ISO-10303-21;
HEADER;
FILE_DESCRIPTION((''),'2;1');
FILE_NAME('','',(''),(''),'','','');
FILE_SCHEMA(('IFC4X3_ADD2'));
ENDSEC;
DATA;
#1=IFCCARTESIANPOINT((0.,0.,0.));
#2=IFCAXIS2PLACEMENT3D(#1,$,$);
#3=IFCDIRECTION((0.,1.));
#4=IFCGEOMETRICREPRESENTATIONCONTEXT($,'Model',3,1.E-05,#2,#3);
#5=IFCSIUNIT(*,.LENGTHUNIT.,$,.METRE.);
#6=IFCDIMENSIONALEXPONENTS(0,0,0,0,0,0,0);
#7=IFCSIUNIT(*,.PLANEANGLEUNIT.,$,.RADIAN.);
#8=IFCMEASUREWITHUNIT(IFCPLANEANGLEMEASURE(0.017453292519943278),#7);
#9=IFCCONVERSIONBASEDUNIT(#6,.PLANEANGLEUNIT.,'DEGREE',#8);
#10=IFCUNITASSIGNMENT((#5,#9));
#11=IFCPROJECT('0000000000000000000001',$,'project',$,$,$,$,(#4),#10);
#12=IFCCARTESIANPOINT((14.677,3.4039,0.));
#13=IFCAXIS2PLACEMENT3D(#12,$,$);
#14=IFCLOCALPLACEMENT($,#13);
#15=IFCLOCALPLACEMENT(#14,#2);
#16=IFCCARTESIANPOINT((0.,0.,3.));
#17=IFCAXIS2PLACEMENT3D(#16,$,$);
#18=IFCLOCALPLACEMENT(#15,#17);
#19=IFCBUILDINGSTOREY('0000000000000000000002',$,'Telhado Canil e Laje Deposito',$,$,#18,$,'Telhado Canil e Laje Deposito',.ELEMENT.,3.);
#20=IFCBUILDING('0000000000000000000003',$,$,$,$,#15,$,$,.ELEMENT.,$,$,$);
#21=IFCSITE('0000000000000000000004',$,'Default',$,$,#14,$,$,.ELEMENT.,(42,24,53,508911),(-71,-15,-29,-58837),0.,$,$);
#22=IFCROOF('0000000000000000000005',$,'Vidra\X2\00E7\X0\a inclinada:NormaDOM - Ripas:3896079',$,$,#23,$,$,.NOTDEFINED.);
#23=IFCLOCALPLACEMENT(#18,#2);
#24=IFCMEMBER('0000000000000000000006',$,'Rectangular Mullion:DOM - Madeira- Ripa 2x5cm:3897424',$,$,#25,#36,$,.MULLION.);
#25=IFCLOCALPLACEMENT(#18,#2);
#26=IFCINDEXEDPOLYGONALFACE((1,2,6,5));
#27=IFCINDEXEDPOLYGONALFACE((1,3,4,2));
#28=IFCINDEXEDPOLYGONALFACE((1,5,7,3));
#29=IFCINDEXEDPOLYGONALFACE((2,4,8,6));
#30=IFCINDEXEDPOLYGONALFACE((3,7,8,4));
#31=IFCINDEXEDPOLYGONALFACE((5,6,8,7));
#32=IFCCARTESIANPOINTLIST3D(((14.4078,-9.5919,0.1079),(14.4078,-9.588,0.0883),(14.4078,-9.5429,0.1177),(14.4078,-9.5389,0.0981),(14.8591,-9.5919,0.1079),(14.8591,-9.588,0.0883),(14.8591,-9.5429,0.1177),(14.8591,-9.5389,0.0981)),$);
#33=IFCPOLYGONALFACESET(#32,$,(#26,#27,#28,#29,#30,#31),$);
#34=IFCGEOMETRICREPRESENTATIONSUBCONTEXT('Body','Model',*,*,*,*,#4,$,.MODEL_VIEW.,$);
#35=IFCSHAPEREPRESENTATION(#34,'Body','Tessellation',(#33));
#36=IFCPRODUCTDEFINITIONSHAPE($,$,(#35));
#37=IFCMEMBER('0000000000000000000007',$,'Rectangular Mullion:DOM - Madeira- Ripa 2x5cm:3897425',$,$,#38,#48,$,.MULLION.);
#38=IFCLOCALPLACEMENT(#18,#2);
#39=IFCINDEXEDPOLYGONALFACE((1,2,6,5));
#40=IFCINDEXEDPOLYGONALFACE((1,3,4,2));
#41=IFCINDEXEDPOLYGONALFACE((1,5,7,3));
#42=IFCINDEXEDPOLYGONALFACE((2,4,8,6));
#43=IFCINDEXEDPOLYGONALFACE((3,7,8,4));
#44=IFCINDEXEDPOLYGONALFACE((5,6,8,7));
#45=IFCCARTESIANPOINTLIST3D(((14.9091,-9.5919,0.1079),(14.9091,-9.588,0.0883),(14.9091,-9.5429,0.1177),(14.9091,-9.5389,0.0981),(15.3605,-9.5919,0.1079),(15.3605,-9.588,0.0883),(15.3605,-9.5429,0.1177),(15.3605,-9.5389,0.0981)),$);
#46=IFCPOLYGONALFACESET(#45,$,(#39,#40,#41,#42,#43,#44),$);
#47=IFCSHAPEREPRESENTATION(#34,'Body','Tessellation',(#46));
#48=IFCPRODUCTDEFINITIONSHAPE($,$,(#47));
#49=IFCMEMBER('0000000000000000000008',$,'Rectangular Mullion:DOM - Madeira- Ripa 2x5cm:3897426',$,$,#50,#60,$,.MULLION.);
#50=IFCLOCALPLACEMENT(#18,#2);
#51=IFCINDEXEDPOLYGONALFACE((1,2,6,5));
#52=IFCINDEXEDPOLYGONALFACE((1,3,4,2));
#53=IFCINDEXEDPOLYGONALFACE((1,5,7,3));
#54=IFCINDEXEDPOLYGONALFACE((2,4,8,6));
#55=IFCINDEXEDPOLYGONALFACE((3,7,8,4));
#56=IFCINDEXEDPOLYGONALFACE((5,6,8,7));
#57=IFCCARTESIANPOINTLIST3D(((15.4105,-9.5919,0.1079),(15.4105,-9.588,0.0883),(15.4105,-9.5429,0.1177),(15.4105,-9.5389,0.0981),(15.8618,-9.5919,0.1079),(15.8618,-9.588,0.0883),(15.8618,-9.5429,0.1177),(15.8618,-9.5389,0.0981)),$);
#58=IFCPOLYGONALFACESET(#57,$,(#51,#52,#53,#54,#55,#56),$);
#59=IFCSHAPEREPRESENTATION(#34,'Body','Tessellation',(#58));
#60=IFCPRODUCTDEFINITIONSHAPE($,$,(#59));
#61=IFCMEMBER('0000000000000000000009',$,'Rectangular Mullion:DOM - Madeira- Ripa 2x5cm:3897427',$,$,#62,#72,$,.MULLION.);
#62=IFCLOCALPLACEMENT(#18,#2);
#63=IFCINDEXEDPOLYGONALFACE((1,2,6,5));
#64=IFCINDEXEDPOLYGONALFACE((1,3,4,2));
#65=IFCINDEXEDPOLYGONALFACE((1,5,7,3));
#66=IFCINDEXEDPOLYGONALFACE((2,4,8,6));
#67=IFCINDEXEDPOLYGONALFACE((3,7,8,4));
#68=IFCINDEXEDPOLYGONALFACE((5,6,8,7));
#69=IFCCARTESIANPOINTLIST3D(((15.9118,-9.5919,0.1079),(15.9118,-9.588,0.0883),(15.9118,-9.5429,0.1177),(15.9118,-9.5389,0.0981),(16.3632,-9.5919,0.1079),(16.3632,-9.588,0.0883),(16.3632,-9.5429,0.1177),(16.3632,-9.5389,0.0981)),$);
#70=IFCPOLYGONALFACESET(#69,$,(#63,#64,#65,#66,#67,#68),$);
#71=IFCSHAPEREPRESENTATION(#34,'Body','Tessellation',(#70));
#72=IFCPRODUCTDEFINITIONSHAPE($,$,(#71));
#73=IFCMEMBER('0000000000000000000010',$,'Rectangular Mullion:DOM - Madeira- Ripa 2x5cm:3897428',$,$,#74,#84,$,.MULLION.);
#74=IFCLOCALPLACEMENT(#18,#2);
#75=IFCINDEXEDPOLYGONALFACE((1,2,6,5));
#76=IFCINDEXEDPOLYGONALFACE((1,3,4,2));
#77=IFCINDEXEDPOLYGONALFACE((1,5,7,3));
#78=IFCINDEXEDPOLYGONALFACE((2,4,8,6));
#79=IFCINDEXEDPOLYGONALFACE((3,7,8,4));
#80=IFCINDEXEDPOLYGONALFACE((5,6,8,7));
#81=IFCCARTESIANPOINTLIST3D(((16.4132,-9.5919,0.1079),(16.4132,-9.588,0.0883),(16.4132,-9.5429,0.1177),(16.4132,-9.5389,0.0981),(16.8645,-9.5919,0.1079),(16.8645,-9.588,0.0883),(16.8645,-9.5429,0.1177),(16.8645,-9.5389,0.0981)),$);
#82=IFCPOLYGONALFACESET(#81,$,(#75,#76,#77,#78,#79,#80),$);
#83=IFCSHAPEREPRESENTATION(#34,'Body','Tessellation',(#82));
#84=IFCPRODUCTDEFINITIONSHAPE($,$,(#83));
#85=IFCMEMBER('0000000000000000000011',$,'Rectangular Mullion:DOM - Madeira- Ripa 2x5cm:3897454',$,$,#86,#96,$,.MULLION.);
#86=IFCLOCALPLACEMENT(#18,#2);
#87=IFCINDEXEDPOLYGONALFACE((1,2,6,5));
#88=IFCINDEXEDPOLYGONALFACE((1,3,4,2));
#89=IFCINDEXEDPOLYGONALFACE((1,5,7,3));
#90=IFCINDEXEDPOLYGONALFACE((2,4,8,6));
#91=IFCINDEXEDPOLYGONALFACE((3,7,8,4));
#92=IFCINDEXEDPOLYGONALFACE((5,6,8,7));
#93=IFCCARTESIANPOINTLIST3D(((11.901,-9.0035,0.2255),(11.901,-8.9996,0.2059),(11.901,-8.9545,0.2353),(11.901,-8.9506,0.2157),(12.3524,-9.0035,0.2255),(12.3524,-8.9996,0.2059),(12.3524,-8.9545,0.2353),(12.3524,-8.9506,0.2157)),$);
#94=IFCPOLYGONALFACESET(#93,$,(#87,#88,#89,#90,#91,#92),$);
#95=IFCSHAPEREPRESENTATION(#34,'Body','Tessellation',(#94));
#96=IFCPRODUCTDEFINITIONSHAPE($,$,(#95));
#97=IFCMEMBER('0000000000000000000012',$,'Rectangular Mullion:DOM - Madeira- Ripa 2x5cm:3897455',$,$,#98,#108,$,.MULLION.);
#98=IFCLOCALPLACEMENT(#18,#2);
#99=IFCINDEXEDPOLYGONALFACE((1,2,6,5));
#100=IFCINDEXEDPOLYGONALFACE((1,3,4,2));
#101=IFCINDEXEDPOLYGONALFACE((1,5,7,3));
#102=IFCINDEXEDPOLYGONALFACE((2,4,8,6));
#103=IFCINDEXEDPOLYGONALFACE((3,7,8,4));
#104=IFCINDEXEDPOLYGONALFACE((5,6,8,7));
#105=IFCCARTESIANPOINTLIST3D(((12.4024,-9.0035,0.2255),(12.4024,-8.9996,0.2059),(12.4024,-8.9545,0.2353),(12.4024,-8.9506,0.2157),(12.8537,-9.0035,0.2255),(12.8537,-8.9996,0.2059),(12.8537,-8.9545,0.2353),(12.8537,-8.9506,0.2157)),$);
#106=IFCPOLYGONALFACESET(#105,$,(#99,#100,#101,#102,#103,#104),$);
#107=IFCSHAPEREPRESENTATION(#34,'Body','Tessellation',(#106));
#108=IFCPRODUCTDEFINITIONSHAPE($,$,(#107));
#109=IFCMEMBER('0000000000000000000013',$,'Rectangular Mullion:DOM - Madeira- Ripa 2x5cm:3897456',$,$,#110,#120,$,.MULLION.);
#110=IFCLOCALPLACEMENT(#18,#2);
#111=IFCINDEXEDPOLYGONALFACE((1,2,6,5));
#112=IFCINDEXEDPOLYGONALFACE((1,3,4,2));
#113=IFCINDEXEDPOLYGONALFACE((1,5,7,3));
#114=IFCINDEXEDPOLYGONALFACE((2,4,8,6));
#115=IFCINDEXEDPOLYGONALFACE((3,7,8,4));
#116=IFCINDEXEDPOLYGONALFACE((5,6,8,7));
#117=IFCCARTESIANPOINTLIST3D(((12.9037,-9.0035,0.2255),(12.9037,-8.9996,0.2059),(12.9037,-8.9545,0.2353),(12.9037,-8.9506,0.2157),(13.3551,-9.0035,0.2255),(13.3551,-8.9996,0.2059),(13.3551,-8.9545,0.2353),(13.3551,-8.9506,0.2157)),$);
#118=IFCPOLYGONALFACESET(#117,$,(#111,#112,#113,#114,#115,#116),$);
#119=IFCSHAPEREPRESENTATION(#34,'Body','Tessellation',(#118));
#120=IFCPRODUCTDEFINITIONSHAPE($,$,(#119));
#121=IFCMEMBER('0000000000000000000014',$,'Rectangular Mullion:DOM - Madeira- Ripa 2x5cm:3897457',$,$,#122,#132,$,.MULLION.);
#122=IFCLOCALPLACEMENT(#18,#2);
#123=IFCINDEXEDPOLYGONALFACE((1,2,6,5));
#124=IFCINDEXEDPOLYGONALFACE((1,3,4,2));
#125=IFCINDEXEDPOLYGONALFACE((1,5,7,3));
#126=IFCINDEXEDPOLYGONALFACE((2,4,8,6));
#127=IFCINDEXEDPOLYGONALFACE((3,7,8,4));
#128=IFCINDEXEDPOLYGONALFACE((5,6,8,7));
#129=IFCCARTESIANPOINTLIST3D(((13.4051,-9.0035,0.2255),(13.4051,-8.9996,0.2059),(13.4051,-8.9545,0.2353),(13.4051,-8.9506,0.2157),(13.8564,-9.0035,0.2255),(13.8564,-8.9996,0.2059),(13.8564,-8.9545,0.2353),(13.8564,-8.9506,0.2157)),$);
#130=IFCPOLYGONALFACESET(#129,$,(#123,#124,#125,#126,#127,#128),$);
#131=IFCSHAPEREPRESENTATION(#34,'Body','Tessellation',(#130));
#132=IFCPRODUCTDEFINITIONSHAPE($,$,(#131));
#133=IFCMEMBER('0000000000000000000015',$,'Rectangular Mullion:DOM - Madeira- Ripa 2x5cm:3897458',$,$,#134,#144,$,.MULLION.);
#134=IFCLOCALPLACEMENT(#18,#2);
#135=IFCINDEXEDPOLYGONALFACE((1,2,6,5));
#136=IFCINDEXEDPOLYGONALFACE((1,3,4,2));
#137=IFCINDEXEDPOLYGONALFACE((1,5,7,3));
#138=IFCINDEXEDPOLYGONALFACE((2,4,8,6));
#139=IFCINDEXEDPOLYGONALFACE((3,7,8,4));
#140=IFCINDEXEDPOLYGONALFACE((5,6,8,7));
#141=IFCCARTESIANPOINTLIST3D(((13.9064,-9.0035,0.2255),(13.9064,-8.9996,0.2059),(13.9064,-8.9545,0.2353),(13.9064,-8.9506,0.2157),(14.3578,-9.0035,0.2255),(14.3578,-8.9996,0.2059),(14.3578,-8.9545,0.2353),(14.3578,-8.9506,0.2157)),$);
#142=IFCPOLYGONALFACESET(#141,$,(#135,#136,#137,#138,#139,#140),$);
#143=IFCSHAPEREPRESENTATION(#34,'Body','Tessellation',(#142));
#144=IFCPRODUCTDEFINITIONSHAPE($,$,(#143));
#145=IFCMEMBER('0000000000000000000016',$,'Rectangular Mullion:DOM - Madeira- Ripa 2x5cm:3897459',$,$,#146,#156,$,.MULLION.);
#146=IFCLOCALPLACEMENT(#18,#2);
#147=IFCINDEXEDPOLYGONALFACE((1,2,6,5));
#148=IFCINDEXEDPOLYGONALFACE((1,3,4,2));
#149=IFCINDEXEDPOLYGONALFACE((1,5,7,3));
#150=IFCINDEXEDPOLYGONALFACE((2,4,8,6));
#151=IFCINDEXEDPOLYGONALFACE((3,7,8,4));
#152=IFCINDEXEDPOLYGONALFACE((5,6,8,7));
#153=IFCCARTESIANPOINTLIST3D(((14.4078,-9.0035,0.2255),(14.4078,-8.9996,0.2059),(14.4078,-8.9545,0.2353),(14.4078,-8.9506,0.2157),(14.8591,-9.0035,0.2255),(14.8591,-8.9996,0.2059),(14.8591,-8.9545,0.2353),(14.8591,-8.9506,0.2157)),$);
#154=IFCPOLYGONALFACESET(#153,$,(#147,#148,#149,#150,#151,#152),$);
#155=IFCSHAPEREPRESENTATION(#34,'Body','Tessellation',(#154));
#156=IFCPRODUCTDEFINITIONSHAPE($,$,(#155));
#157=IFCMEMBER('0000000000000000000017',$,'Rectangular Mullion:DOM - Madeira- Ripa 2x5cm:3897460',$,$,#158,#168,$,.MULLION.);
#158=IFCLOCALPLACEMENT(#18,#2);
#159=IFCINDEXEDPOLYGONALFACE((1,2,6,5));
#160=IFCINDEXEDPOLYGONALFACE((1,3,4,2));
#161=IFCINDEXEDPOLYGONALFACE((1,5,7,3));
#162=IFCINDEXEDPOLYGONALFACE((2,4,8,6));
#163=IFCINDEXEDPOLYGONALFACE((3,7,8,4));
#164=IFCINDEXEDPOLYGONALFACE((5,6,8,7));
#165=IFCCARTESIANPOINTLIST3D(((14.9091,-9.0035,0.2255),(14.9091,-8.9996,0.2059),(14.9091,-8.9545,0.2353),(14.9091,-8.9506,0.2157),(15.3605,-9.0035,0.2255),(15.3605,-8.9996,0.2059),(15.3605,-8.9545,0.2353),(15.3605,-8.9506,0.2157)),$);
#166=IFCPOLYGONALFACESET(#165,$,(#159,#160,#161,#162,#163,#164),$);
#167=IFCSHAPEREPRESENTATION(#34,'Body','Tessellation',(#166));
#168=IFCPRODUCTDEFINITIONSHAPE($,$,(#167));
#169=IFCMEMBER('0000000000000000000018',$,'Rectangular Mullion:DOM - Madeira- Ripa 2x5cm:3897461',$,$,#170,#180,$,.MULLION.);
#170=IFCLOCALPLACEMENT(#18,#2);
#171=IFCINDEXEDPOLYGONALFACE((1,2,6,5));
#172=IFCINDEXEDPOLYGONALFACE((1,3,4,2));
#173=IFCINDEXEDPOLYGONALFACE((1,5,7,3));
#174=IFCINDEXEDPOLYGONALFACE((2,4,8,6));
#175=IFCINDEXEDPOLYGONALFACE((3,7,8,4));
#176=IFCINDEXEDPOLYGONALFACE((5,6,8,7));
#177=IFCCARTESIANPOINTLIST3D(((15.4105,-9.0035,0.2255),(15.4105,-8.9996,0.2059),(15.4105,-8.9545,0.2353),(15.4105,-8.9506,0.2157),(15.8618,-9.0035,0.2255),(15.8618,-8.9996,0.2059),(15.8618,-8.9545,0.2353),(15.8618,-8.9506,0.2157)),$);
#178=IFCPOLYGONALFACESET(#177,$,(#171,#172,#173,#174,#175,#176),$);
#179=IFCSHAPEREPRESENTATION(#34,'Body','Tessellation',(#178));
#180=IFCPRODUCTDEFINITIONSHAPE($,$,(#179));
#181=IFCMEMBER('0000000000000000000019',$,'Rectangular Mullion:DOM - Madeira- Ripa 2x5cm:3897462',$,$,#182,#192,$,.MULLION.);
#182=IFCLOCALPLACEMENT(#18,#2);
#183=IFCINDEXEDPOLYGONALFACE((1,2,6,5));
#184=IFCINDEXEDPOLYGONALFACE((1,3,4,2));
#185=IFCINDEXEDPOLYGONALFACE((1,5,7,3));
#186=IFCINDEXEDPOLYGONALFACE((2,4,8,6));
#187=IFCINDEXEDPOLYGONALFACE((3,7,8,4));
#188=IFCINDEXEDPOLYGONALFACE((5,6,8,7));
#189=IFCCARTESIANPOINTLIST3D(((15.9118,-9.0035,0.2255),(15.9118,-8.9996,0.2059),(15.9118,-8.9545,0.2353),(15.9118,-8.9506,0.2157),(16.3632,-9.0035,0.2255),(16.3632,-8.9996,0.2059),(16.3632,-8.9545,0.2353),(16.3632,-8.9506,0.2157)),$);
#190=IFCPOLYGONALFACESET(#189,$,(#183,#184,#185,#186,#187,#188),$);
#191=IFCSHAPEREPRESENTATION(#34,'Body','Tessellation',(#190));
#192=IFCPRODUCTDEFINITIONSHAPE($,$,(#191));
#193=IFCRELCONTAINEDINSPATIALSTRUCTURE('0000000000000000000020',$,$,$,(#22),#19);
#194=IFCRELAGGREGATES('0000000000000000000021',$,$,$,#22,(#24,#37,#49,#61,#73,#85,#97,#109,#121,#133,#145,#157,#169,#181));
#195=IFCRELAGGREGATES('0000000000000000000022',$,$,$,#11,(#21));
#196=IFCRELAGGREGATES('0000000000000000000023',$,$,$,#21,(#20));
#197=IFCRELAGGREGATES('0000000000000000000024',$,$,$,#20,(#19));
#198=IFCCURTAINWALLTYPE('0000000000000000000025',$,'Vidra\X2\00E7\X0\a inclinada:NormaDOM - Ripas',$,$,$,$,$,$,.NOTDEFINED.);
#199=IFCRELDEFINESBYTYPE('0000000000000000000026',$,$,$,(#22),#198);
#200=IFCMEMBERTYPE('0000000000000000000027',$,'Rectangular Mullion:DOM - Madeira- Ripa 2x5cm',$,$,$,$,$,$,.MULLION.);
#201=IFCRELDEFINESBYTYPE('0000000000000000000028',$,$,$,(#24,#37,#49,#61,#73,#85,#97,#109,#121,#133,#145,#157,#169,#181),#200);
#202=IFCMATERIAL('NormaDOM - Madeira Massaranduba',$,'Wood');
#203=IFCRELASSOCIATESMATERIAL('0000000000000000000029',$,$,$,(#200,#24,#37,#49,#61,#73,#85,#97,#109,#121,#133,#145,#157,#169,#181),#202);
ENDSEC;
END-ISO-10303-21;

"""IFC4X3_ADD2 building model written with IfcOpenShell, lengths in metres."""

from ifc_helpers import new_model, entity, si_unit, converted_unit, direction, frame, origin, origin_2d_with_axis, place, context, subcontext, project, spatial, rectangle, extrude, source, transform, mapped, material, material_profile, profile_set, profile_usage, type_object, type_shapes, element, aggregate, save


model = new_model("IFC4X3_ADD2")

# Units and contexts
model_context = context("Model", 3, precision=1e-05, world=origin(), true_north=direction((0.0, 1.0)))
body_context = subcontext(model_context, "Body", "Model", "MODEL_VIEW")
ifc_project = project(units=[si_unit("LENGTHUNIT", "METRE"), converted_unit("PLANEANGLEUNIT", "DEGREE", entity("IfcPlaneAngleMeasure", 0.017453292519943278), si_unit("PLANEANGLEUNIT", "RADIAN"), dimensions=[0, 0, 0, 0, 0, 0, 0])], contexts=[model_context])

# Site, building, storey
site_placement = place(None, frame((14.677, 3.4039, 0.0)))
site = spatial("IfcSite", under=ifc_project, at=site_placement, Name="Default", CompositionType="ELEMENT", RefLatitude=(42, 24, 53, 508911), RefLongitude=(-71, -15, -29, -58837), RefElevation=0.0)
building_placement = place(site_placement, origin())
building = spatial("IfcBuilding", under=site, at=building_placement, CompositionType="ELEMENT")
storey_placement = place(building_placement, frame((0.0, 0.0, 3.0)))
storey = spatial("IfcBuildingStorey", under=building, at=storey_placement, Name="Telhado Canil e Laje Deposito", LongName="Telhado Canil e Laje Deposito", CompositionType="ELEMENT", Elevation=3.0)

# Shared definitions
ifc_material = material(Name="NormaDOM - Madeira Massaranduba", Category="Wood")

# Roof, members
ifc_material_profile_1 = material_profile(ifc_material, rectangle(XDim=0.05, YDim=0.02, at=origin_2d_with_axis()), Name="DOM - Madeira- Ripa 2x5cm")
ifc_profile_set_1 = profile_set([ifc_material_profile_1], Name="DOM - Madeira- Ripa 2x5cm")
ifc_profile_usage_1 = profile_usage(ifc_profile_set_1)
curtain_wall_type_1 = type_object("IfcCurtainWallType", Name="Vidraça inclinada:NormaDOM - Ripas", PredefinedType="NOTDEFINED")
roof_1_placement = place(storey_placement, frame((0.0, 0.0, -3.0)))
roof_1 = element("IfcRoof", 1, at=roof_1_placement, inside=storey, type_object=curtain_wall_type_1, Name="Vidraça inclinada:NormaDOM - Ripas:3896079", PredefinedType="NOTDEFINED")
member_type_1 = type_object("IfcMemberType", Name="Rectangular Mullion:DOM - Madeira- Ripa 2x5cm", PredefinedType="MULLION", material=ifc_profile_set_1)
shared_shape_1 = source(origin(), body_context, "Body", "SweptSolid", [
    extrude(rectangle(XDim=0.05, YDim=0.02, at=origin_2d_with_axis()), frame((0.025, 0.01, -0.4514), z_axis=(0.0, 0.0, 1.0), x_axis=(-1.0, 0.0, 0.0)), (0.0, 0.0, 1.0), 0.4514),
])
type_shapes(member_type_1, [shared_shape_1])
member_1_placement = place(roof_1_placement, frame((14.4078, -9.5919, 3.1079), z_axis=(-1.0, 0.0, 0.0), x_axis=(0.0, 0.980581, 0.196116)))
member_1 = element("IfcMember", 2, at=member_1_placement, type_object=member_type_1, material=ifc_profile_usage_1, Name="Rectangular Mullion:DOM - Madeira- Ripa 2x5cm:3897424", PredefinedType="MULLION", context=body_context, shape_type="MappedRepresentation", body=[
    mapped(shared_shape_1, transform((0.0, 0.0, 0.0), scale=1.0)),
])
member_2_placement = place(roof_1_placement, frame((14.9091, -9.5919, 3.1079), z_axis=(-1.0, 0.0, 0.0), x_axis=(0.0, 0.980581, 0.196116)))
member_2 = element("IfcMember", 3, at=member_2_placement, type_object=member_type_1, material=ifc_profile_usage_1, Name="Rectangular Mullion:DOM - Madeira- Ripa 2x5cm:3897425", PredefinedType="MULLION", context=body_context, shape_type="MappedRepresentation", body=[
    mapped(shared_shape_1, transform((0.0, 0.0, 0.0), scale=1.0)),
])
member_3_placement = place(roof_1_placement, frame((15.4105, -9.5919, 3.1079), z_axis=(-1.0, 0.0, 0.0), x_axis=(0.0, 0.980581, 0.196116)))
member_3 = element("IfcMember", 4, at=member_3_placement, type_object=member_type_1, material=ifc_profile_usage_1, Name="Rectangular Mullion:DOM - Madeira- Ripa 2x5cm:3897426", PredefinedType="MULLION", context=body_context, shape_type="MappedRepresentation", body=[
    mapped(shared_shape_1, transform((0.0, 0.0, 0.0), scale=1.0)),
])
member_4_placement = place(roof_1_placement, frame((15.9118, -9.5919, 3.1079), z_axis=(-1.0, 0.0, 0.0), x_axis=(0.0, 0.980581, 0.196116)))
member_4 = element("IfcMember", 5, at=member_4_placement, type_object=member_type_1, material=ifc_profile_usage_1, Name="Rectangular Mullion:DOM - Madeira- Ripa 2x5cm:3897427", PredefinedType="MULLION", context=body_context, shape_type="MappedRepresentation", body=[
    mapped(shared_shape_1, transform((0.0, 0.0, 0.0), scale=1.0)),
])
member_5_placement = place(roof_1_placement, frame((16.4132, -9.5919, 3.1079), z_axis=(-1.0, 0.0, 0.0), x_axis=(0.0, 0.980581, 0.196116)))
member_5 = element("IfcMember", 6, at=member_5_placement, type_object=member_type_1, material=ifc_profile_usage_1, Name="Rectangular Mullion:DOM - Madeira- Ripa 2x5cm:3897428", PredefinedType="MULLION", context=body_context, shape_type="MappedRepresentation", body=[
    mapped(shared_shape_1, transform((0.0, 0.0, 0.0), scale=1.0)),
])
member_6_placement = place(roof_1_placement, frame((11.901, -9.0035, 3.2255), z_axis=(-1.0, 0.0, 0.0), x_axis=(0.0, 0.980581, 0.196116)))
member_6 = element("IfcMember", 7, at=member_6_placement, type_object=member_type_1, material=ifc_profile_usage_1, Name="Rectangular Mullion:DOM - Madeira- Ripa 2x5cm:3897454", PredefinedType="MULLION", context=body_context, shape_type="MappedRepresentation", body=[
    mapped(shared_shape_1, transform((0.0, 0.0, 0.0), scale=1.0)),
])
member_7_placement = place(roof_1_placement, frame((12.4024, -9.0035, 3.2255), z_axis=(-1.0, 0.0, 0.0), x_axis=(0.0, 0.980581, 0.196116)))
member_7 = element("IfcMember", 8, at=member_7_placement, type_object=member_type_1, material=ifc_profile_usage_1, Name="Rectangular Mullion:DOM - Madeira- Ripa 2x5cm:3897455", PredefinedType="MULLION", context=body_context, shape_type="MappedRepresentation", body=[
    mapped(shared_shape_1, transform((0.0, 0.0, 0.0), scale=1.0)),
])
member_8_placement = place(roof_1_placement, frame((12.9037, -9.0035, 3.2255), z_axis=(-1.0, 0.0, 0.0), x_axis=(0.0, 0.980581, 0.196116)))
member_8 = element("IfcMember", 9, at=member_8_placement, type_object=member_type_1, material=ifc_profile_usage_1, Name="Rectangular Mullion:DOM - Madeira- Ripa 2x5cm:3897456", PredefinedType="MULLION", context=body_context, shape_type="MappedRepresentation", body=[
    mapped(shared_shape_1, transform((0.0, 0.0, 0.0), scale=1.0)),
])
member_9_placement = place(roof_1_placement, frame((13.4051, -9.0035, 3.2255), z_axis=(-1.0, 0.0, 0.0), x_axis=(0.0, 0.980581, 0.196116)))
member_9 = element("IfcMember", 10, at=member_9_placement, type_object=member_type_1, material=ifc_profile_usage_1, Name="Rectangular Mullion:DOM - Madeira- Ripa 2x5cm:3897457", PredefinedType="MULLION", context=body_context, shape_type="MappedRepresentation", body=[
    mapped(shared_shape_1, transform((0.0, 0.0, 0.0), scale=1.0)),
])
member_10_placement = place(roof_1_placement, frame((13.9064, -9.0035, 3.2255), z_axis=(-1.0, 0.0, 0.0), x_axis=(0.0, 0.980581, 0.196116)))
member_10 = element("IfcMember", 11, at=member_10_placement, type_object=member_type_1, material=ifc_profile_usage_1, Name="Rectangular Mullion:DOM - Madeira- Ripa 2x5cm:3897458", PredefinedType="MULLION", context=body_context, shape_type="MappedRepresentation", body=[
    mapped(shared_shape_1, transform((0.0, 0.0, 0.0), scale=1.0)),
])
member_11_placement = place(roof_1_placement, frame((14.4078, -9.0035, 3.2255), z_axis=(-1.0, 0.0, 0.0), x_axis=(0.0, 0.980581, 0.196116)))
member_11 = element("IfcMember", 12, at=member_11_placement, type_object=member_type_1, material=ifc_profile_usage_1, Name="Rectangular Mullion:DOM - Madeira- Ripa 2x5cm:3897459", PredefinedType="MULLION", context=body_context, shape_type="MappedRepresentation", body=[
    mapped(shared_shape_1, transform((0.0, 0.0, 0.0), scale=1.0)),
])
member_12_placement = place(roof_1_placement, frame((14.9091, -9.0035, 3.2255), z_axis=(-1.0, 0.0, 0.0), x_axis=(0.0, 0.980581, 0.196116)))
member_12 = element("IfcMember", 13, at=member_12_placement, type_object=member_type_1, material=ifc_profile_usage_1, Name="Rectangular Mullion:DOM - Madeira- Ripa 2x5cm:3897460", PredefinedType="MULLION", context=body_context, shape_type="MappedRepresentation", body=[
    mapped(shared_shape_1, transform((0.0, 0.0, 0.0), scale=1.0)),
])
member_13_placement = place(roof_1_placement, frame((15.4105, -9.0035, 3.2255), z_axis=(-1.0, 0.0, 0.0), x_axis=(0.0, 0.980581, 0.196116)))
member_13 = element("IfcMember", 14, at=member_13_placement, type_object=member_type_1, material=ifc_profile_usage_1, Name="Rectangular Mullion:DOM - Madeira- Ripa 2x5cm:3897461", PredefinedType="MULLION", context=body_context, shape_type="MappedRepresentation", body=[
    mapped(shared_shape_1, transform((0.0, 0.0, 0.0), scale=1.0)),
])
member_14_placement = place(roof_1_placement, frame((15.9118, -9.0035, 3.2255), z_axis=(-1.0, 0.0, 0.0), x_axis=(0.0, 0.980581, 0.196116)))
member_14 = element("IfcMember", 15, at=member_14_placement, type_object=member_type_1, material=ifc_profile_usage_1, Name="Rectangular Mullion:DOM - Madeira- Ripa 2x5cm:3897462", PredefinedType="MULLION", context=body_context, shape_type="MappedRepresentation", body=[
    mapped(shared_shape_1, transform((0.0, 0.0, 0.0), scale=1.0)),
])
aggregate(roof_1, [member_1, member_2, member_3, member_4, member_5, member_6, member_7, member_8, member_9, member_10, member_11, member_12, member_13, member_14])

save(model, "model.ifc")
